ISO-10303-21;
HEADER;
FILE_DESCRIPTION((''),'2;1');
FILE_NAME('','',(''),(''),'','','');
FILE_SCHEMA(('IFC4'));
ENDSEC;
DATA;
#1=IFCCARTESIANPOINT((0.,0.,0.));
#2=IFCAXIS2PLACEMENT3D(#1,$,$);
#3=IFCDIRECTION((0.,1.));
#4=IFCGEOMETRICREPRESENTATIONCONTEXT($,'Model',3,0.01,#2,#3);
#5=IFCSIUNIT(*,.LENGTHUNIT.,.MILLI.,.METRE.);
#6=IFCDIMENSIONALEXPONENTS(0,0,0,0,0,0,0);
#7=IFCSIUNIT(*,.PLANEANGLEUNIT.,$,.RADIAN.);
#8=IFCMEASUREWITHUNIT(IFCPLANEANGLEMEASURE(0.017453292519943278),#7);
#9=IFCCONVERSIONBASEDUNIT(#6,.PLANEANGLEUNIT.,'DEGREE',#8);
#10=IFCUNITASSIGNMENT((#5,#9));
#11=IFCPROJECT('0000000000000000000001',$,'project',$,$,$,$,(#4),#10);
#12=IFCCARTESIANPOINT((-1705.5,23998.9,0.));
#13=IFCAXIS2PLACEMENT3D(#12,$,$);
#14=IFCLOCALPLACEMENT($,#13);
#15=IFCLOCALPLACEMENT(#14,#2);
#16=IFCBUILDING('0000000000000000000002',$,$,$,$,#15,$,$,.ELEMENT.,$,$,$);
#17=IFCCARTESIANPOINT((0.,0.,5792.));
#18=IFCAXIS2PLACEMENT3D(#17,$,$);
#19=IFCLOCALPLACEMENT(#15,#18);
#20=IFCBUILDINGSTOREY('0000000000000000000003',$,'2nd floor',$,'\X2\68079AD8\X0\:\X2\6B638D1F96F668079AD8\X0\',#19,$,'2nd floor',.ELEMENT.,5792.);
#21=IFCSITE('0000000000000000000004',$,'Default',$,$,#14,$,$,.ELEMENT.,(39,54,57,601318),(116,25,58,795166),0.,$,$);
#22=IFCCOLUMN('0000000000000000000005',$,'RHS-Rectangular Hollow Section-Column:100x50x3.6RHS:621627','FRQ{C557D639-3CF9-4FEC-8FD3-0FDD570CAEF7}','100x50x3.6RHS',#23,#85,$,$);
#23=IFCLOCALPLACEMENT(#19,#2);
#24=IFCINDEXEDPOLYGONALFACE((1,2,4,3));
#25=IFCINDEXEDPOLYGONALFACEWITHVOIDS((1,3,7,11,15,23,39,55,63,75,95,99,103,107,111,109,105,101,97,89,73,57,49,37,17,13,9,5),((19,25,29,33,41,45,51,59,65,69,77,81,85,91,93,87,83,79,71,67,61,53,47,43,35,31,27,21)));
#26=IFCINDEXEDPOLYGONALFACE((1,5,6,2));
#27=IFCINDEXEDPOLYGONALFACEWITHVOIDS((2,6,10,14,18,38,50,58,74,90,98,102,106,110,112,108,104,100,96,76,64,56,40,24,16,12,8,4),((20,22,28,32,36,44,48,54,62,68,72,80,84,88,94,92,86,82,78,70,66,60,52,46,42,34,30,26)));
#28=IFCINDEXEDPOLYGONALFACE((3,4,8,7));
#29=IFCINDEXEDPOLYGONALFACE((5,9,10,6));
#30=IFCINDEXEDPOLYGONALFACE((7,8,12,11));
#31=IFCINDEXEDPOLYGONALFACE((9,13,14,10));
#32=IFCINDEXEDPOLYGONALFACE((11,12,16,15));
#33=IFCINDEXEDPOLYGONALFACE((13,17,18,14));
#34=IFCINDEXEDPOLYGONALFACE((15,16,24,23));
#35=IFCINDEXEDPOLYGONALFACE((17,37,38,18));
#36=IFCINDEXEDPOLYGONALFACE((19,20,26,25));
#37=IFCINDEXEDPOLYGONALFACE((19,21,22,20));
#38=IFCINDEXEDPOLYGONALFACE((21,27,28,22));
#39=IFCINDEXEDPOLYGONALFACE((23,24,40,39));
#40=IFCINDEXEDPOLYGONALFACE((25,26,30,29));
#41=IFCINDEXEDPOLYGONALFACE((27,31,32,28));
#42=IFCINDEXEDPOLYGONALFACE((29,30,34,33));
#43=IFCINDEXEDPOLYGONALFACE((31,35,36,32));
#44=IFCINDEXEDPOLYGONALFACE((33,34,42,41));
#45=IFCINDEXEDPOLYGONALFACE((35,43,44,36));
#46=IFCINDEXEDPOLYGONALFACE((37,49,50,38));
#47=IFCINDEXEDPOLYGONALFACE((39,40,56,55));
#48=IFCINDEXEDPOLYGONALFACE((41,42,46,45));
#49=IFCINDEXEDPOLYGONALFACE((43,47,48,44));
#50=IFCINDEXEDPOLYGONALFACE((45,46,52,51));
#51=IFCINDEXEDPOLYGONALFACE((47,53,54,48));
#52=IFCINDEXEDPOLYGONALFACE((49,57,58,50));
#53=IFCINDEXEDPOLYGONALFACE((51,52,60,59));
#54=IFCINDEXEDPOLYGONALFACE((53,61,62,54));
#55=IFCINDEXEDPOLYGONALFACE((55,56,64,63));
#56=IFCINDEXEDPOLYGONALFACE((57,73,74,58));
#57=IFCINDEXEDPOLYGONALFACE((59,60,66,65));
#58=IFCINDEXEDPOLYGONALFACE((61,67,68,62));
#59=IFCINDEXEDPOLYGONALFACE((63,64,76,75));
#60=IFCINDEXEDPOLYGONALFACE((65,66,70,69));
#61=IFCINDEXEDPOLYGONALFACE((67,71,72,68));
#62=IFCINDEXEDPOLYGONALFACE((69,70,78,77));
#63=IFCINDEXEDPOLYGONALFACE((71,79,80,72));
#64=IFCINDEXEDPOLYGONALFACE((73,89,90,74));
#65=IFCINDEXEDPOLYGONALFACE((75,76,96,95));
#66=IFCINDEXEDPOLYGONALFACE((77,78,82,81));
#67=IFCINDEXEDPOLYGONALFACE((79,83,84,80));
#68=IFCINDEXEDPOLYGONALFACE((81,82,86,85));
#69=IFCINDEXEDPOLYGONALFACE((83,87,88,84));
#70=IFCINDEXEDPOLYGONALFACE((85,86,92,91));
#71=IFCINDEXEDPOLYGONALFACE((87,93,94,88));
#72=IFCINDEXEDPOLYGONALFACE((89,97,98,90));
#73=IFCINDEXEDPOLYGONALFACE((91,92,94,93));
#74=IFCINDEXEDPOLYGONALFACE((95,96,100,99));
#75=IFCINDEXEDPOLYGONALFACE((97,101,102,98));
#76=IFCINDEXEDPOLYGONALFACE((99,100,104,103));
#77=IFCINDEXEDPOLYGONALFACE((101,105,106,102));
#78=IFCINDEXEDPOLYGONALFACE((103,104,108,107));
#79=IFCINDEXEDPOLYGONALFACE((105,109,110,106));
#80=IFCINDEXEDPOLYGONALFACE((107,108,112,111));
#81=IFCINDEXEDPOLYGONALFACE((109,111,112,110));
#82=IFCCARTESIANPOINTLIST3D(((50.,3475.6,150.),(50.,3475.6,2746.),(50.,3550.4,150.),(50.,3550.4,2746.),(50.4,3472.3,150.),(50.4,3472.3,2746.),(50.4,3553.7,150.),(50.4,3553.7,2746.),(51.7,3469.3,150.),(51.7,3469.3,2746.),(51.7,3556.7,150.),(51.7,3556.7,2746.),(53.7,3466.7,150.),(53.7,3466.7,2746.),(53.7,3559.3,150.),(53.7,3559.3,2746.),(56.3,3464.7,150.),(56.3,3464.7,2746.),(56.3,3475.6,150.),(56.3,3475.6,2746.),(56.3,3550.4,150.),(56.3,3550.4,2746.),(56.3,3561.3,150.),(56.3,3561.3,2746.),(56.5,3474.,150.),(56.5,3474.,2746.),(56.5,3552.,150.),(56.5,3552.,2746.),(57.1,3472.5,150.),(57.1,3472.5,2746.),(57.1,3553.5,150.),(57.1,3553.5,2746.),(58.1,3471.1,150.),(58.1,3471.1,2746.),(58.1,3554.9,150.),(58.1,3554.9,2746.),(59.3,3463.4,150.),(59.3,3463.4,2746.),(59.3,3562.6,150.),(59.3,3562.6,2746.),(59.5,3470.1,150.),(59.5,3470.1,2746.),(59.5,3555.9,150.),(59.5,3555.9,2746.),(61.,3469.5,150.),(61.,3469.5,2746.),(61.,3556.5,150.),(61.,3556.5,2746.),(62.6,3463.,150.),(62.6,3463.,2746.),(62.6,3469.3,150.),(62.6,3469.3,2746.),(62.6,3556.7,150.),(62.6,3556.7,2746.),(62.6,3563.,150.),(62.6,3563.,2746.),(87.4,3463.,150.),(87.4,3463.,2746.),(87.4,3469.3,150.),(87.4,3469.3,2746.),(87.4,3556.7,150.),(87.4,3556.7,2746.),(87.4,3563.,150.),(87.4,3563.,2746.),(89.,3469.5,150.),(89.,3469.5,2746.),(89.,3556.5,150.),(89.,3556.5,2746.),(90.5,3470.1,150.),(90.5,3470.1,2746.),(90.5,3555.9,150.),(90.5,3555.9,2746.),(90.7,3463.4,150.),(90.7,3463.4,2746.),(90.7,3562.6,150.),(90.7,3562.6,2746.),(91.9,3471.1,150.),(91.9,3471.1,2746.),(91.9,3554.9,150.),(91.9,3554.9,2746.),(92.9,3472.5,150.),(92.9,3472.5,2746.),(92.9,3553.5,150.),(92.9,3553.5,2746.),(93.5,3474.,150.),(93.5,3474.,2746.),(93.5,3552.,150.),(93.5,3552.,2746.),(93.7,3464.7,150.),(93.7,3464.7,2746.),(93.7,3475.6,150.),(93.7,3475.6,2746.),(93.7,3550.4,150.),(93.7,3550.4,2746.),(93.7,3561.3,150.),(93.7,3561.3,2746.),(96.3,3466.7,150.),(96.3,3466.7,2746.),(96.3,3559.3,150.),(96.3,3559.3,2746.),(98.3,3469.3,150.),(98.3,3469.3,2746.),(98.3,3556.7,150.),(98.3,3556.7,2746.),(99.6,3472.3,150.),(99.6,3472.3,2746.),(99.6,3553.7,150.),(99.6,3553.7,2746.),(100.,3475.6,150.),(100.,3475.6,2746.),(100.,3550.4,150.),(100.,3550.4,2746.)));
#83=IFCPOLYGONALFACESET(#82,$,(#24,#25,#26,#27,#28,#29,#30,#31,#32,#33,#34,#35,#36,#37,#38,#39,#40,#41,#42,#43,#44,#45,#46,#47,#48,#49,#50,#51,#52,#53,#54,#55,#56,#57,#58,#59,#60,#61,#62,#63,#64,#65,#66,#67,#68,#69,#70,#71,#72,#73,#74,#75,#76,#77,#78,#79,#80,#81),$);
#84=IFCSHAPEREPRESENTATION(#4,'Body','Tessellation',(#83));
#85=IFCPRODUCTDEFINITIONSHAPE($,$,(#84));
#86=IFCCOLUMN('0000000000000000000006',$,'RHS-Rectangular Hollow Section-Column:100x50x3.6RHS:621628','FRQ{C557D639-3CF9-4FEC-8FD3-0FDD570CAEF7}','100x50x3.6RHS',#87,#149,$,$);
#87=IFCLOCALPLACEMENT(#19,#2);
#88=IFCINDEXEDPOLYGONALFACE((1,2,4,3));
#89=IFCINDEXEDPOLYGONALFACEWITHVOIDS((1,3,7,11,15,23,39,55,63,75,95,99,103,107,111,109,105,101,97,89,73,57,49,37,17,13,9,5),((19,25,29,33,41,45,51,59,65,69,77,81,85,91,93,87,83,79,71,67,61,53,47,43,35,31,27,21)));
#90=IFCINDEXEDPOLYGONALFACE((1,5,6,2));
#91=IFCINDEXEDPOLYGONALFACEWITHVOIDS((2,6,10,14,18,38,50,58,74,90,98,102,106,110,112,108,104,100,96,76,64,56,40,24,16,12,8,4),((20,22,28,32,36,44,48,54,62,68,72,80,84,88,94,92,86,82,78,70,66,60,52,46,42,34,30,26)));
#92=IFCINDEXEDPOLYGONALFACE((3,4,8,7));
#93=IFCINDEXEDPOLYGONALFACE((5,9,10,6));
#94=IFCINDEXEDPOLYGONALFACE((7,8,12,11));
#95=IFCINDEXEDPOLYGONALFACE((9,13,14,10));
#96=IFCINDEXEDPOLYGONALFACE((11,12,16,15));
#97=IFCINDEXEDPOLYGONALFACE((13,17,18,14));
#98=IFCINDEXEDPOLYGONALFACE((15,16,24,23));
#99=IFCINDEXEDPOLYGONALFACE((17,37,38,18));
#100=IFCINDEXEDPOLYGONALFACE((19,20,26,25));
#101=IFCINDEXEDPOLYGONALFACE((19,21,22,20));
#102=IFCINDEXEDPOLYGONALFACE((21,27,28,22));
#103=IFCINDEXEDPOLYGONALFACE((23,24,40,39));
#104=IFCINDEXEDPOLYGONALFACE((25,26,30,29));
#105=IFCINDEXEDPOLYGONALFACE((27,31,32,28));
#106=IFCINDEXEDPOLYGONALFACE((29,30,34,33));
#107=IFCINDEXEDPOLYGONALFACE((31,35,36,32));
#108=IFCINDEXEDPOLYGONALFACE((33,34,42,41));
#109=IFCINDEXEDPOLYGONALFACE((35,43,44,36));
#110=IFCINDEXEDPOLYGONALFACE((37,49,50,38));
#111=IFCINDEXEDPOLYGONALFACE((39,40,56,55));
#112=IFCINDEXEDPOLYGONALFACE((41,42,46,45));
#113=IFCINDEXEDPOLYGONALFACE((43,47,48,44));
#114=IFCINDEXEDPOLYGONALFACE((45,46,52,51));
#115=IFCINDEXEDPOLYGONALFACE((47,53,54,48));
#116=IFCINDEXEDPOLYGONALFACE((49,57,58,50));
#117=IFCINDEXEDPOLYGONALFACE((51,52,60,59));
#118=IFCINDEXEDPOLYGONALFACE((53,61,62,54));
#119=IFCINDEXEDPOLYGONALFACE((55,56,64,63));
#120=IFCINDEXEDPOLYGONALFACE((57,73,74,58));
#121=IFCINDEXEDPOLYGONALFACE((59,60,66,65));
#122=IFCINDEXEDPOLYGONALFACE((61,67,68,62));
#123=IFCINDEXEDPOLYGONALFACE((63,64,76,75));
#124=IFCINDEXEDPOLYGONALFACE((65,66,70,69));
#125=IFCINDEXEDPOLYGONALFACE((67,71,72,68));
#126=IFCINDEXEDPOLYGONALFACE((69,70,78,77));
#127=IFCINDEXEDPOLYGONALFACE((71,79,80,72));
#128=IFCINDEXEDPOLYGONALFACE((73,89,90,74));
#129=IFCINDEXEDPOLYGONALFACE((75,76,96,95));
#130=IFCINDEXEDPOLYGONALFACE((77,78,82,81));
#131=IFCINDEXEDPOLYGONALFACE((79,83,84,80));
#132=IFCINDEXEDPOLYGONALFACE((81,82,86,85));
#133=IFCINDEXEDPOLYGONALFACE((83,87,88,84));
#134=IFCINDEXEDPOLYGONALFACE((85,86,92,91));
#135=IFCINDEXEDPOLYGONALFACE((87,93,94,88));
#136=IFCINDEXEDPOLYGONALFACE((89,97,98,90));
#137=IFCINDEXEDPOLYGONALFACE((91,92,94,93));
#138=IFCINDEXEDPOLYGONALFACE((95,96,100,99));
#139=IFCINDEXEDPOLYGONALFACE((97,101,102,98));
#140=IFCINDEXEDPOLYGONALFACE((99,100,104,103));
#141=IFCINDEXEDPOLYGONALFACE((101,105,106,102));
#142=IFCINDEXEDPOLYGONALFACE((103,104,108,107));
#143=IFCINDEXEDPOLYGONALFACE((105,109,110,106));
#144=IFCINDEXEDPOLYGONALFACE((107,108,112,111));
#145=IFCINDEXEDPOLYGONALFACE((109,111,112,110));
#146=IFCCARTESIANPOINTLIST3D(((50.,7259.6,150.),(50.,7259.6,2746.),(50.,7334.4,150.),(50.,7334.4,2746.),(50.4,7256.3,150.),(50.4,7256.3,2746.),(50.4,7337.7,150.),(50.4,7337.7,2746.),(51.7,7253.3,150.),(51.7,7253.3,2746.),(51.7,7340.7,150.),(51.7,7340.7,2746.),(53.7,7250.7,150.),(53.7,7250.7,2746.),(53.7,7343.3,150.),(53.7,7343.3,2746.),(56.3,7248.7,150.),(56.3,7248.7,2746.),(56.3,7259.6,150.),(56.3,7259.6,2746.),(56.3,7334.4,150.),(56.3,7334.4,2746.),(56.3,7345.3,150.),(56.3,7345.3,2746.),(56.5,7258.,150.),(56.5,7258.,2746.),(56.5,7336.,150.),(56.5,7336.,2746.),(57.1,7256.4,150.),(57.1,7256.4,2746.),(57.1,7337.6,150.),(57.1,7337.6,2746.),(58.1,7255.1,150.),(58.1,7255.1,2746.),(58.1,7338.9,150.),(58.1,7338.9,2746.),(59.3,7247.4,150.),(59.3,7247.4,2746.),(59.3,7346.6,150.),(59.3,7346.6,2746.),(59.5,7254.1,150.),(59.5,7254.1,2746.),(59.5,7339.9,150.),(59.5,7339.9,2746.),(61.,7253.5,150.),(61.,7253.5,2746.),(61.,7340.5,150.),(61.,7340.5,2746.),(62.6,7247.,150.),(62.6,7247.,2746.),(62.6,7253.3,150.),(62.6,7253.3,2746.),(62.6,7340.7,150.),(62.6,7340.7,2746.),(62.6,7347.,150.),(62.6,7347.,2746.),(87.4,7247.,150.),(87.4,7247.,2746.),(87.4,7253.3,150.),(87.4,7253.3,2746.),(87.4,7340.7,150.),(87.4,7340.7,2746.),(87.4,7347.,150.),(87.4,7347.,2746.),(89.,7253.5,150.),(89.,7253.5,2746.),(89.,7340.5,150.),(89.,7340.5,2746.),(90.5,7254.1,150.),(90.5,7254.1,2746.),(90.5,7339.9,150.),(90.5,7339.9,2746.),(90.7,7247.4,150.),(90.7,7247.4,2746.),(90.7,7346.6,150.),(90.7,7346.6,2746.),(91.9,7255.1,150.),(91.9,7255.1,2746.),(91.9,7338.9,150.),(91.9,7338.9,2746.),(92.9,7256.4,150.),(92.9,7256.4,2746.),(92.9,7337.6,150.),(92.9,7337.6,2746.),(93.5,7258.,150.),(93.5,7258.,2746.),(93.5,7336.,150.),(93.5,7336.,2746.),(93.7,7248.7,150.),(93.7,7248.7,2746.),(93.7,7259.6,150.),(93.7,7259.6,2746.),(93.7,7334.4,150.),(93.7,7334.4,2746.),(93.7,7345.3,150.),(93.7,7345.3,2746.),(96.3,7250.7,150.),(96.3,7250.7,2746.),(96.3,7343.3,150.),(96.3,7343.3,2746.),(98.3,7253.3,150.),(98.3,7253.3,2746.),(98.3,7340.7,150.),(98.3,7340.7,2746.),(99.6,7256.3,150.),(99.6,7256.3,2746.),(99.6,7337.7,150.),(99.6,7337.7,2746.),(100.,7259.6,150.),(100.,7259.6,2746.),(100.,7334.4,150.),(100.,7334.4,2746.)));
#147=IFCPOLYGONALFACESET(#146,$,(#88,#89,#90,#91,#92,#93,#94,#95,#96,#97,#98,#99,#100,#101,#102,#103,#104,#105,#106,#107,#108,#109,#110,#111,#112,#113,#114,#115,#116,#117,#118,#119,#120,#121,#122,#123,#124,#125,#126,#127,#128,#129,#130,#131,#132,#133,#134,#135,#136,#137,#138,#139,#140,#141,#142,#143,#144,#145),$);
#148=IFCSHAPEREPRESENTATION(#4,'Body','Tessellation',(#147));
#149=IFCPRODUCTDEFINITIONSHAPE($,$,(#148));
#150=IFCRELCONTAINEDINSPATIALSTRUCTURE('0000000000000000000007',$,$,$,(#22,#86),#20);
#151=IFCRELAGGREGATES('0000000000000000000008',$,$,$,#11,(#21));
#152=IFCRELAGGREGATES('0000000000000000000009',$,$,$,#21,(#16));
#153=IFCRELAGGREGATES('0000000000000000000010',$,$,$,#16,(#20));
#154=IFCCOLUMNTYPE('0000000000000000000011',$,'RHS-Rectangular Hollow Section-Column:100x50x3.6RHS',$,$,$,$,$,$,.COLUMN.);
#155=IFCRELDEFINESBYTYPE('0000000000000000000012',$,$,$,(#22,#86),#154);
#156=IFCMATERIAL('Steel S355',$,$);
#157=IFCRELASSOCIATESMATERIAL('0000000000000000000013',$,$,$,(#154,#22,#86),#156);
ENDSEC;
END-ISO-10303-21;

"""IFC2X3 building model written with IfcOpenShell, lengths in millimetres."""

from ifc_helpers import new_model, entity, si_unit, converted_unit, direction, frame, origin, origin_2d, place, context, project, spatial, hollow_rectangle, extrude, clip, halfspace, material, type_object, element, save


model = new_model("IFC2X3")

# Units and contexts
model_context = context("Model", 3, precision=0.01, world=origin(), true_north=direction((0.0, 1.0)))
ifc_project = project(units=[si_unit("LENGTHUNIT", "METRE", prefix="MILLI"), converted_unit("PLANEANGLEUNIT", "DEGREE", entity("IfcPlaneAngleMeasure", 0.017453292519943278), si_unit("PLANEANGLEUNIT", "RADIAN"), dimensions=[0, 0, 0, 0, 0, 0, 0])], contexts=[model_context])

# Site, building, storey
site_placement = place(None, frame((-1705.5, 23998.9, 0.0)))
site = spatial("IfcSite", under=ifc_project, at=site_placement, Name="Default", CompositionType="ELEMENT", RefLatitude=(39, 54, 57, 601318), RefLongitude=(116, 25, 58, 795166), RefElevation=0.0)
building_placement = place(site_placement, origin())
building = spatial("IfcBuilding", under=site, at=building_placement, CompositionType="ELEMENT")
storey_placement = place(building_placement, frame((0.0, 0.0, 5792.0)))
storey = spatial("IfcBuildingStorey", under=building, at=storey_placement, Name="2nd floor", ObjectType="标高:正负零标高", LongName="2nd floor", CompositionType="ELEMENT", Elevation=5792.0)

# Shared definitions
ifc_material_1 = material(Name="Steel S355")

# Columns
column_type_1 = type_object("IfcColumnType", Name="RHS-Rectangular Hollow Section-Column:100x50x3.6RHS", PredefinedType="COLUMN", material=ifc_material_1)
column_1_placement = place(storey_placement, frame((75.0, 3513.0, 2746.0), z_axis=(0.0, 0.0, 1.0), x_axis=(-1.0, 0.0, 0.0)))
element("IfcColumn", 1, at=column_1_placement, inside=storey, type_object=column_type_1, material=ifc_material_1, Name="RHS-Rectangular Hollow Section-Column:100x50x3.6RHS:621627", Description="FRQ{C557D639-3CF9-4FEC-8FD3-0FDD570CAEF7}", ObjectType="100x50x3.6RHS", context=model_context, shape_type="Clipping", body=[
    clip(extrude(hollow_rectangle(XDim=50.0, YDim=100.0, WallThickness=6.3, InnerFilletRadius=6.3, OuterFilletRadius=12.6, at=origin_2d()), origin(), (0.0, 0.0, -1.0), 2651.9), halfspace(frame((75.0, 3513.0, -2596.0), z_axis=(0.0, 0.0, 1.0), x_axis=(-1.0, 0.0, 0.0)), True)),
])
column_2_placement = place(storey_placement, frame((75.0, 7297.0, 2746.0), z_axis=(0.0, 0.0, 1.0), x_axis=(-1.0, 0.0, 0.0)))
element("IfcColumn", 2, at=column_2_placement, inside=storey, type_object=column_type_1, material=ifc_material_1, Name="RHS-Rectangular Hollow Section-Column:100x50x3.6RHS:621628", Description="FRQ{C557D639-3CF9-4FEC-8FD3-0FDD570CAEF7}", ObjectType="100x50x3.6RHS", context=model_context, shape_type="Clipping", body=[
    clip(extrude(hollow_rectangle(XDim=50.0, YDim=100.0, WallThickness=6.3, InnerFilletRadius=6.3, OuterFilletRadius=12.6, at=origin_2d()), origin(), (0.0, 0.0, -1.0), 2651.9), halfspace(frame((75.0, 7297.0, -2596.0), z_axis=(0.0, 0.0, 1.0), x_axis=(-1.0, 0.0, 0.0)), True)),
])

save(model, "model.ifc")
